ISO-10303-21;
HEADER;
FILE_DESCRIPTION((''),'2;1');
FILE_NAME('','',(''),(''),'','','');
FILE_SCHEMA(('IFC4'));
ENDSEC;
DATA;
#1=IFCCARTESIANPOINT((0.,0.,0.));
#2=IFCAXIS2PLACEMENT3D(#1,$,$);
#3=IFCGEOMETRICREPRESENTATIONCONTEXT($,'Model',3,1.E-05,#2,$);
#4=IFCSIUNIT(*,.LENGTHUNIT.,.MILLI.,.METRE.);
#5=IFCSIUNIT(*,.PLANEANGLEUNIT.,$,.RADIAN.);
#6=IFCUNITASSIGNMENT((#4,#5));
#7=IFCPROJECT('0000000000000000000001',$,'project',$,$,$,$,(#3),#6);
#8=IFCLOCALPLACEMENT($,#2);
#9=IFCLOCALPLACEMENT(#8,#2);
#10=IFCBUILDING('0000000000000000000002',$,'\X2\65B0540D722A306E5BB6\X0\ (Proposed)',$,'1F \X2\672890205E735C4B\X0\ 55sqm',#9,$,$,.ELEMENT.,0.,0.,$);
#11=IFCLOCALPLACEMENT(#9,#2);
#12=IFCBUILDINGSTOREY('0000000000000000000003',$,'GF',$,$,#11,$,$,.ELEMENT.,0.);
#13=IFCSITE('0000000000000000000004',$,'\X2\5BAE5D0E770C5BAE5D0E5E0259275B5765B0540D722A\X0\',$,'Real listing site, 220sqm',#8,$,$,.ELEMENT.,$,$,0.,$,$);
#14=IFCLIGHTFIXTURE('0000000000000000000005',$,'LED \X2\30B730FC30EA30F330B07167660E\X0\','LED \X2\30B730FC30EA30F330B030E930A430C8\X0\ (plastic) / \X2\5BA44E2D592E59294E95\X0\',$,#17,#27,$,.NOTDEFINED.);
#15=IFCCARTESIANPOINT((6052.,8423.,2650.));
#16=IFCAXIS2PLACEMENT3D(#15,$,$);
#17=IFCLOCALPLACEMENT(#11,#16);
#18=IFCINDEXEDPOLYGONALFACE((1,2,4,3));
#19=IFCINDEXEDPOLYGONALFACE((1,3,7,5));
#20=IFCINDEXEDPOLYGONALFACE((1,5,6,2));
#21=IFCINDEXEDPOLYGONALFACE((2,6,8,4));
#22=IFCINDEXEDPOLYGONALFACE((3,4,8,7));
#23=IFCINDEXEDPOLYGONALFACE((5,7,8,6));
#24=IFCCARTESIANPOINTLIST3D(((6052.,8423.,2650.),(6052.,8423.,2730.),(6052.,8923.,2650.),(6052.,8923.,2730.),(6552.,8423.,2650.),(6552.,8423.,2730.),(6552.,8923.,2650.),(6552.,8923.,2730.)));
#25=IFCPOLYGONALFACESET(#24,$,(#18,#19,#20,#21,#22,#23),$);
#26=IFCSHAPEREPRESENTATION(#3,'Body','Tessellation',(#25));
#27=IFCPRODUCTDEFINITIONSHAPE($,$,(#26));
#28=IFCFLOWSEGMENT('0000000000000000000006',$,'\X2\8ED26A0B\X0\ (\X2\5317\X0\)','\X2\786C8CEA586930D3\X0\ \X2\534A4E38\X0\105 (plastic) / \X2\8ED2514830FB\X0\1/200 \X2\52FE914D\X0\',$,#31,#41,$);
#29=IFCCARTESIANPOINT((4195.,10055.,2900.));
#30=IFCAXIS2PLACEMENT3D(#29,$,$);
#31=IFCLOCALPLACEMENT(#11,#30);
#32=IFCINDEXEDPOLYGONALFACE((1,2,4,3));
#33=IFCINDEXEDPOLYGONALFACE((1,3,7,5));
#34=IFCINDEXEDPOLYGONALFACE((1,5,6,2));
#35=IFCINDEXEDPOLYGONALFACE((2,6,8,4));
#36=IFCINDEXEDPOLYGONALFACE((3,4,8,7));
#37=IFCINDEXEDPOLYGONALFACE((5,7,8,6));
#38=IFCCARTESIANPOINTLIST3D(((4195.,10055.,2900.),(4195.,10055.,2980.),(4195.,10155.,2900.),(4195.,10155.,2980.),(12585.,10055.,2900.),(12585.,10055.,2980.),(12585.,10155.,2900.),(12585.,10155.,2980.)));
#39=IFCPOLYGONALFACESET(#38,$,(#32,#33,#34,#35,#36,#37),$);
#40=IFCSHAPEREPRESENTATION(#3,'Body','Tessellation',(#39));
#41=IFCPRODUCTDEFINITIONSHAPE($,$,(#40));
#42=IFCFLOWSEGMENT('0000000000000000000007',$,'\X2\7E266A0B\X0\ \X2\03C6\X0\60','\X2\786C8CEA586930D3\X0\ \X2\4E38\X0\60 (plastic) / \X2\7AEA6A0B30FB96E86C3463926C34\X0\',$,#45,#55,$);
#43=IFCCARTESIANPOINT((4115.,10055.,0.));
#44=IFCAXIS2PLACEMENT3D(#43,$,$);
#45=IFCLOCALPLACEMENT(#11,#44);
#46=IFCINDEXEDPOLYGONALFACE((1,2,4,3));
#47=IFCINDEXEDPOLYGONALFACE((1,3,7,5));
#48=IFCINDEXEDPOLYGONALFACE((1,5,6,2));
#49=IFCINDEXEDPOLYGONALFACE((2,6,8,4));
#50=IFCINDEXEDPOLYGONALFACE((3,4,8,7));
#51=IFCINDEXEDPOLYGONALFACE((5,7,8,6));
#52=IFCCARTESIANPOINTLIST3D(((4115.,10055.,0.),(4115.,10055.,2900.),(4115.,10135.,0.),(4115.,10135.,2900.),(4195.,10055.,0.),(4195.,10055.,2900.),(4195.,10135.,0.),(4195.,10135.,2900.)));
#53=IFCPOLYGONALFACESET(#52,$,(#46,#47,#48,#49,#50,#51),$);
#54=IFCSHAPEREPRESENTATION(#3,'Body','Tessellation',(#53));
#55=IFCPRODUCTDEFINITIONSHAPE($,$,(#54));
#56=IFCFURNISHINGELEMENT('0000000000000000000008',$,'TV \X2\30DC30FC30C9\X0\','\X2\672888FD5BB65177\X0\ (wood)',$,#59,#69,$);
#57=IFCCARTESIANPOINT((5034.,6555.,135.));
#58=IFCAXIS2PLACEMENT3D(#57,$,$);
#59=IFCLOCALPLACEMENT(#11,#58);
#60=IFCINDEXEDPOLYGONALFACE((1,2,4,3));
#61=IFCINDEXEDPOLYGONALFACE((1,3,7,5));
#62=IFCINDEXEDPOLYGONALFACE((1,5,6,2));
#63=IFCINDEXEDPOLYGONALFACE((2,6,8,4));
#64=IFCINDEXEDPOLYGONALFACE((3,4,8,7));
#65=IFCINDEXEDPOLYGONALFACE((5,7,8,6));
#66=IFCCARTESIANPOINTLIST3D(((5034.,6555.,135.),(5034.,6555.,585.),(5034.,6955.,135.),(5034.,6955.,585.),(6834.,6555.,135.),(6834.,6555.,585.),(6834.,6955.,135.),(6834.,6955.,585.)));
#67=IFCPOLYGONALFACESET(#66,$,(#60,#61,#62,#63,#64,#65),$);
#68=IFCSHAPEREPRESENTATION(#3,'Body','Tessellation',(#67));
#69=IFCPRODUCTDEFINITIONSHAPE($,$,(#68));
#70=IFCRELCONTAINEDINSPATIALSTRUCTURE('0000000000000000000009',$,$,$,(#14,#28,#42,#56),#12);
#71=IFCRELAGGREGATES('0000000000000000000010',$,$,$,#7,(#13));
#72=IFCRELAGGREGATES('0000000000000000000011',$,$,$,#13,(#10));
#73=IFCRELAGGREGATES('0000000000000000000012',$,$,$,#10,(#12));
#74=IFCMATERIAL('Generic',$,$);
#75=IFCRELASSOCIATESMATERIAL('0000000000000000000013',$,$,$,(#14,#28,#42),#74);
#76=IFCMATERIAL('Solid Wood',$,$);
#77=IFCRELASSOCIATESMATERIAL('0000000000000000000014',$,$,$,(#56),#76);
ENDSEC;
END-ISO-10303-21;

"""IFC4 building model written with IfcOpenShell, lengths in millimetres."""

from ifc_helpers import new_model, si_unit, frame, frame_2d, origin, place, context, project, spatial, rectangle, extrude, material, element, save


model = new_model("IFC4")

# Units and contexts
model_context = context("Model", 3, precision=1e-05, world=origin())
ifc_project = project(units=[si_unit("LENGTHUNIT", "METRE", prefix="MILLI"), si_unit("PLANEANGLEUNIT", "RADIAN")], contexts=[model_context])

# Site, building, storey
site_placement = place(None, origin())
site = spatial("IfcSite", under=ifc_project, at=site_placement, Name="宮崎県宮崎市大字新名爪", ObjectType="Real listing site, 220sqm", CompositionType="ELEMENT", RefElevation=0.0)
building_placement = place(site_placement, origin())
building = spatial("IfcBuilding", under=site, at=building_placement, Name="新名爪の家 (Proposed)", ObjectType="1F 木造平屋 55sqm", CompositionType="ELEMENT", ElevationOfRefHeight=0.0, ElevationOfTerrain=0.0)
storey_placement = place(building_placement, origin())
storey = spatial("IfcBuildingStorey", under=building, at=storey_placement, Name="GF", CompositionType="ELEMENT", Elevation=0.0)

# Shared definitions
ifc_material_1 = material(Name="Solid Wood")

# Shared definitions
ifc_material_2 = material(Name="Generic")

# Light fixture
light_fixture_placement = place(storey_placement, frame((6052.0, 8423.0, 2650.0)))
element("IfcLightFixture", 1, at=light_fixture_placement, inside=storey, material=ifc_material_2, Name="LED シーリング照明", Description="LED シーリングライト (plastic) / 室中央天井", PredefinedType="NOTDEFINED", context=model_context, shape_type="SweptSolid", body=[
    extrude(rectangle(XDim=500.0, YDim=500.0, at=frame_2d((250.0, 250.0))), frame((6052.0, 8423.0, 2650.0)), (0.0, 0.0, 1.0), 80.0),
])

# Flow segments
flow_segment_1_placement = place(storey_placement, frame((4195.0, 10055.0, 2900.0)))
element("IfcFlowSegment", 2, at=flow_segment_1_placement, inside=storey, material=ifc_material_2, Name="軒樋 (北)", Description="硬質塩ビ 半丸105 (plastic) / 軒先・1/200 勾配", context=model_context, shape_type="SweptSolid", body=[
    extrude(rectangle(XDim=8390.0, YDim=100.0, at=frame_2d((4195.0, 50.0))), frame((4195.0, 10055.0, 2900.0)), (0.0, 0.0, 1.0), 80.0),
])
flow_segment_2_placement = place(storey_placement, frame((4115.0, 10055.0, 0.0)))
element("IfcFlowSegment", 3, at=flow_segment_2_placement, inside=storey, material=ifc_material_2, Name="縦樋 φ60", Description="硬質塩ビ 丸60 (plastic) / 竪樋・雨水排水", context=model_context, shape_type="SweptSolid", body=[
    extrude(rectangle(XDim=80.0, YDim=80.0, at=frame_2d((40.0, 40.0))), frame((4115.0, 10055.0, 0.0)), (0.0, 0.0, 1.0), 2900.0),
])

# Furnishing element
furnishing_placement = place(storey_placement, frame((5034.0, 6555.0, 135.0)))
element("IfcFurnishingElement", 4, at=furnishing_placement, inside=storey, material=ifc_material_1, Name="TV ボード", Description="木製家具 (wood)", context=model_context, shape_type="SweptSolid", body=[
    extrude(rectangle(XDim=1800.0, YDim=400.0, at=frame_2d((900.0, 200.0))), frame((5034.0, 6555.0, 135.0)), (0.0, 0.0, 1.0), 450.0),
])

save(model, "model.ifc")
